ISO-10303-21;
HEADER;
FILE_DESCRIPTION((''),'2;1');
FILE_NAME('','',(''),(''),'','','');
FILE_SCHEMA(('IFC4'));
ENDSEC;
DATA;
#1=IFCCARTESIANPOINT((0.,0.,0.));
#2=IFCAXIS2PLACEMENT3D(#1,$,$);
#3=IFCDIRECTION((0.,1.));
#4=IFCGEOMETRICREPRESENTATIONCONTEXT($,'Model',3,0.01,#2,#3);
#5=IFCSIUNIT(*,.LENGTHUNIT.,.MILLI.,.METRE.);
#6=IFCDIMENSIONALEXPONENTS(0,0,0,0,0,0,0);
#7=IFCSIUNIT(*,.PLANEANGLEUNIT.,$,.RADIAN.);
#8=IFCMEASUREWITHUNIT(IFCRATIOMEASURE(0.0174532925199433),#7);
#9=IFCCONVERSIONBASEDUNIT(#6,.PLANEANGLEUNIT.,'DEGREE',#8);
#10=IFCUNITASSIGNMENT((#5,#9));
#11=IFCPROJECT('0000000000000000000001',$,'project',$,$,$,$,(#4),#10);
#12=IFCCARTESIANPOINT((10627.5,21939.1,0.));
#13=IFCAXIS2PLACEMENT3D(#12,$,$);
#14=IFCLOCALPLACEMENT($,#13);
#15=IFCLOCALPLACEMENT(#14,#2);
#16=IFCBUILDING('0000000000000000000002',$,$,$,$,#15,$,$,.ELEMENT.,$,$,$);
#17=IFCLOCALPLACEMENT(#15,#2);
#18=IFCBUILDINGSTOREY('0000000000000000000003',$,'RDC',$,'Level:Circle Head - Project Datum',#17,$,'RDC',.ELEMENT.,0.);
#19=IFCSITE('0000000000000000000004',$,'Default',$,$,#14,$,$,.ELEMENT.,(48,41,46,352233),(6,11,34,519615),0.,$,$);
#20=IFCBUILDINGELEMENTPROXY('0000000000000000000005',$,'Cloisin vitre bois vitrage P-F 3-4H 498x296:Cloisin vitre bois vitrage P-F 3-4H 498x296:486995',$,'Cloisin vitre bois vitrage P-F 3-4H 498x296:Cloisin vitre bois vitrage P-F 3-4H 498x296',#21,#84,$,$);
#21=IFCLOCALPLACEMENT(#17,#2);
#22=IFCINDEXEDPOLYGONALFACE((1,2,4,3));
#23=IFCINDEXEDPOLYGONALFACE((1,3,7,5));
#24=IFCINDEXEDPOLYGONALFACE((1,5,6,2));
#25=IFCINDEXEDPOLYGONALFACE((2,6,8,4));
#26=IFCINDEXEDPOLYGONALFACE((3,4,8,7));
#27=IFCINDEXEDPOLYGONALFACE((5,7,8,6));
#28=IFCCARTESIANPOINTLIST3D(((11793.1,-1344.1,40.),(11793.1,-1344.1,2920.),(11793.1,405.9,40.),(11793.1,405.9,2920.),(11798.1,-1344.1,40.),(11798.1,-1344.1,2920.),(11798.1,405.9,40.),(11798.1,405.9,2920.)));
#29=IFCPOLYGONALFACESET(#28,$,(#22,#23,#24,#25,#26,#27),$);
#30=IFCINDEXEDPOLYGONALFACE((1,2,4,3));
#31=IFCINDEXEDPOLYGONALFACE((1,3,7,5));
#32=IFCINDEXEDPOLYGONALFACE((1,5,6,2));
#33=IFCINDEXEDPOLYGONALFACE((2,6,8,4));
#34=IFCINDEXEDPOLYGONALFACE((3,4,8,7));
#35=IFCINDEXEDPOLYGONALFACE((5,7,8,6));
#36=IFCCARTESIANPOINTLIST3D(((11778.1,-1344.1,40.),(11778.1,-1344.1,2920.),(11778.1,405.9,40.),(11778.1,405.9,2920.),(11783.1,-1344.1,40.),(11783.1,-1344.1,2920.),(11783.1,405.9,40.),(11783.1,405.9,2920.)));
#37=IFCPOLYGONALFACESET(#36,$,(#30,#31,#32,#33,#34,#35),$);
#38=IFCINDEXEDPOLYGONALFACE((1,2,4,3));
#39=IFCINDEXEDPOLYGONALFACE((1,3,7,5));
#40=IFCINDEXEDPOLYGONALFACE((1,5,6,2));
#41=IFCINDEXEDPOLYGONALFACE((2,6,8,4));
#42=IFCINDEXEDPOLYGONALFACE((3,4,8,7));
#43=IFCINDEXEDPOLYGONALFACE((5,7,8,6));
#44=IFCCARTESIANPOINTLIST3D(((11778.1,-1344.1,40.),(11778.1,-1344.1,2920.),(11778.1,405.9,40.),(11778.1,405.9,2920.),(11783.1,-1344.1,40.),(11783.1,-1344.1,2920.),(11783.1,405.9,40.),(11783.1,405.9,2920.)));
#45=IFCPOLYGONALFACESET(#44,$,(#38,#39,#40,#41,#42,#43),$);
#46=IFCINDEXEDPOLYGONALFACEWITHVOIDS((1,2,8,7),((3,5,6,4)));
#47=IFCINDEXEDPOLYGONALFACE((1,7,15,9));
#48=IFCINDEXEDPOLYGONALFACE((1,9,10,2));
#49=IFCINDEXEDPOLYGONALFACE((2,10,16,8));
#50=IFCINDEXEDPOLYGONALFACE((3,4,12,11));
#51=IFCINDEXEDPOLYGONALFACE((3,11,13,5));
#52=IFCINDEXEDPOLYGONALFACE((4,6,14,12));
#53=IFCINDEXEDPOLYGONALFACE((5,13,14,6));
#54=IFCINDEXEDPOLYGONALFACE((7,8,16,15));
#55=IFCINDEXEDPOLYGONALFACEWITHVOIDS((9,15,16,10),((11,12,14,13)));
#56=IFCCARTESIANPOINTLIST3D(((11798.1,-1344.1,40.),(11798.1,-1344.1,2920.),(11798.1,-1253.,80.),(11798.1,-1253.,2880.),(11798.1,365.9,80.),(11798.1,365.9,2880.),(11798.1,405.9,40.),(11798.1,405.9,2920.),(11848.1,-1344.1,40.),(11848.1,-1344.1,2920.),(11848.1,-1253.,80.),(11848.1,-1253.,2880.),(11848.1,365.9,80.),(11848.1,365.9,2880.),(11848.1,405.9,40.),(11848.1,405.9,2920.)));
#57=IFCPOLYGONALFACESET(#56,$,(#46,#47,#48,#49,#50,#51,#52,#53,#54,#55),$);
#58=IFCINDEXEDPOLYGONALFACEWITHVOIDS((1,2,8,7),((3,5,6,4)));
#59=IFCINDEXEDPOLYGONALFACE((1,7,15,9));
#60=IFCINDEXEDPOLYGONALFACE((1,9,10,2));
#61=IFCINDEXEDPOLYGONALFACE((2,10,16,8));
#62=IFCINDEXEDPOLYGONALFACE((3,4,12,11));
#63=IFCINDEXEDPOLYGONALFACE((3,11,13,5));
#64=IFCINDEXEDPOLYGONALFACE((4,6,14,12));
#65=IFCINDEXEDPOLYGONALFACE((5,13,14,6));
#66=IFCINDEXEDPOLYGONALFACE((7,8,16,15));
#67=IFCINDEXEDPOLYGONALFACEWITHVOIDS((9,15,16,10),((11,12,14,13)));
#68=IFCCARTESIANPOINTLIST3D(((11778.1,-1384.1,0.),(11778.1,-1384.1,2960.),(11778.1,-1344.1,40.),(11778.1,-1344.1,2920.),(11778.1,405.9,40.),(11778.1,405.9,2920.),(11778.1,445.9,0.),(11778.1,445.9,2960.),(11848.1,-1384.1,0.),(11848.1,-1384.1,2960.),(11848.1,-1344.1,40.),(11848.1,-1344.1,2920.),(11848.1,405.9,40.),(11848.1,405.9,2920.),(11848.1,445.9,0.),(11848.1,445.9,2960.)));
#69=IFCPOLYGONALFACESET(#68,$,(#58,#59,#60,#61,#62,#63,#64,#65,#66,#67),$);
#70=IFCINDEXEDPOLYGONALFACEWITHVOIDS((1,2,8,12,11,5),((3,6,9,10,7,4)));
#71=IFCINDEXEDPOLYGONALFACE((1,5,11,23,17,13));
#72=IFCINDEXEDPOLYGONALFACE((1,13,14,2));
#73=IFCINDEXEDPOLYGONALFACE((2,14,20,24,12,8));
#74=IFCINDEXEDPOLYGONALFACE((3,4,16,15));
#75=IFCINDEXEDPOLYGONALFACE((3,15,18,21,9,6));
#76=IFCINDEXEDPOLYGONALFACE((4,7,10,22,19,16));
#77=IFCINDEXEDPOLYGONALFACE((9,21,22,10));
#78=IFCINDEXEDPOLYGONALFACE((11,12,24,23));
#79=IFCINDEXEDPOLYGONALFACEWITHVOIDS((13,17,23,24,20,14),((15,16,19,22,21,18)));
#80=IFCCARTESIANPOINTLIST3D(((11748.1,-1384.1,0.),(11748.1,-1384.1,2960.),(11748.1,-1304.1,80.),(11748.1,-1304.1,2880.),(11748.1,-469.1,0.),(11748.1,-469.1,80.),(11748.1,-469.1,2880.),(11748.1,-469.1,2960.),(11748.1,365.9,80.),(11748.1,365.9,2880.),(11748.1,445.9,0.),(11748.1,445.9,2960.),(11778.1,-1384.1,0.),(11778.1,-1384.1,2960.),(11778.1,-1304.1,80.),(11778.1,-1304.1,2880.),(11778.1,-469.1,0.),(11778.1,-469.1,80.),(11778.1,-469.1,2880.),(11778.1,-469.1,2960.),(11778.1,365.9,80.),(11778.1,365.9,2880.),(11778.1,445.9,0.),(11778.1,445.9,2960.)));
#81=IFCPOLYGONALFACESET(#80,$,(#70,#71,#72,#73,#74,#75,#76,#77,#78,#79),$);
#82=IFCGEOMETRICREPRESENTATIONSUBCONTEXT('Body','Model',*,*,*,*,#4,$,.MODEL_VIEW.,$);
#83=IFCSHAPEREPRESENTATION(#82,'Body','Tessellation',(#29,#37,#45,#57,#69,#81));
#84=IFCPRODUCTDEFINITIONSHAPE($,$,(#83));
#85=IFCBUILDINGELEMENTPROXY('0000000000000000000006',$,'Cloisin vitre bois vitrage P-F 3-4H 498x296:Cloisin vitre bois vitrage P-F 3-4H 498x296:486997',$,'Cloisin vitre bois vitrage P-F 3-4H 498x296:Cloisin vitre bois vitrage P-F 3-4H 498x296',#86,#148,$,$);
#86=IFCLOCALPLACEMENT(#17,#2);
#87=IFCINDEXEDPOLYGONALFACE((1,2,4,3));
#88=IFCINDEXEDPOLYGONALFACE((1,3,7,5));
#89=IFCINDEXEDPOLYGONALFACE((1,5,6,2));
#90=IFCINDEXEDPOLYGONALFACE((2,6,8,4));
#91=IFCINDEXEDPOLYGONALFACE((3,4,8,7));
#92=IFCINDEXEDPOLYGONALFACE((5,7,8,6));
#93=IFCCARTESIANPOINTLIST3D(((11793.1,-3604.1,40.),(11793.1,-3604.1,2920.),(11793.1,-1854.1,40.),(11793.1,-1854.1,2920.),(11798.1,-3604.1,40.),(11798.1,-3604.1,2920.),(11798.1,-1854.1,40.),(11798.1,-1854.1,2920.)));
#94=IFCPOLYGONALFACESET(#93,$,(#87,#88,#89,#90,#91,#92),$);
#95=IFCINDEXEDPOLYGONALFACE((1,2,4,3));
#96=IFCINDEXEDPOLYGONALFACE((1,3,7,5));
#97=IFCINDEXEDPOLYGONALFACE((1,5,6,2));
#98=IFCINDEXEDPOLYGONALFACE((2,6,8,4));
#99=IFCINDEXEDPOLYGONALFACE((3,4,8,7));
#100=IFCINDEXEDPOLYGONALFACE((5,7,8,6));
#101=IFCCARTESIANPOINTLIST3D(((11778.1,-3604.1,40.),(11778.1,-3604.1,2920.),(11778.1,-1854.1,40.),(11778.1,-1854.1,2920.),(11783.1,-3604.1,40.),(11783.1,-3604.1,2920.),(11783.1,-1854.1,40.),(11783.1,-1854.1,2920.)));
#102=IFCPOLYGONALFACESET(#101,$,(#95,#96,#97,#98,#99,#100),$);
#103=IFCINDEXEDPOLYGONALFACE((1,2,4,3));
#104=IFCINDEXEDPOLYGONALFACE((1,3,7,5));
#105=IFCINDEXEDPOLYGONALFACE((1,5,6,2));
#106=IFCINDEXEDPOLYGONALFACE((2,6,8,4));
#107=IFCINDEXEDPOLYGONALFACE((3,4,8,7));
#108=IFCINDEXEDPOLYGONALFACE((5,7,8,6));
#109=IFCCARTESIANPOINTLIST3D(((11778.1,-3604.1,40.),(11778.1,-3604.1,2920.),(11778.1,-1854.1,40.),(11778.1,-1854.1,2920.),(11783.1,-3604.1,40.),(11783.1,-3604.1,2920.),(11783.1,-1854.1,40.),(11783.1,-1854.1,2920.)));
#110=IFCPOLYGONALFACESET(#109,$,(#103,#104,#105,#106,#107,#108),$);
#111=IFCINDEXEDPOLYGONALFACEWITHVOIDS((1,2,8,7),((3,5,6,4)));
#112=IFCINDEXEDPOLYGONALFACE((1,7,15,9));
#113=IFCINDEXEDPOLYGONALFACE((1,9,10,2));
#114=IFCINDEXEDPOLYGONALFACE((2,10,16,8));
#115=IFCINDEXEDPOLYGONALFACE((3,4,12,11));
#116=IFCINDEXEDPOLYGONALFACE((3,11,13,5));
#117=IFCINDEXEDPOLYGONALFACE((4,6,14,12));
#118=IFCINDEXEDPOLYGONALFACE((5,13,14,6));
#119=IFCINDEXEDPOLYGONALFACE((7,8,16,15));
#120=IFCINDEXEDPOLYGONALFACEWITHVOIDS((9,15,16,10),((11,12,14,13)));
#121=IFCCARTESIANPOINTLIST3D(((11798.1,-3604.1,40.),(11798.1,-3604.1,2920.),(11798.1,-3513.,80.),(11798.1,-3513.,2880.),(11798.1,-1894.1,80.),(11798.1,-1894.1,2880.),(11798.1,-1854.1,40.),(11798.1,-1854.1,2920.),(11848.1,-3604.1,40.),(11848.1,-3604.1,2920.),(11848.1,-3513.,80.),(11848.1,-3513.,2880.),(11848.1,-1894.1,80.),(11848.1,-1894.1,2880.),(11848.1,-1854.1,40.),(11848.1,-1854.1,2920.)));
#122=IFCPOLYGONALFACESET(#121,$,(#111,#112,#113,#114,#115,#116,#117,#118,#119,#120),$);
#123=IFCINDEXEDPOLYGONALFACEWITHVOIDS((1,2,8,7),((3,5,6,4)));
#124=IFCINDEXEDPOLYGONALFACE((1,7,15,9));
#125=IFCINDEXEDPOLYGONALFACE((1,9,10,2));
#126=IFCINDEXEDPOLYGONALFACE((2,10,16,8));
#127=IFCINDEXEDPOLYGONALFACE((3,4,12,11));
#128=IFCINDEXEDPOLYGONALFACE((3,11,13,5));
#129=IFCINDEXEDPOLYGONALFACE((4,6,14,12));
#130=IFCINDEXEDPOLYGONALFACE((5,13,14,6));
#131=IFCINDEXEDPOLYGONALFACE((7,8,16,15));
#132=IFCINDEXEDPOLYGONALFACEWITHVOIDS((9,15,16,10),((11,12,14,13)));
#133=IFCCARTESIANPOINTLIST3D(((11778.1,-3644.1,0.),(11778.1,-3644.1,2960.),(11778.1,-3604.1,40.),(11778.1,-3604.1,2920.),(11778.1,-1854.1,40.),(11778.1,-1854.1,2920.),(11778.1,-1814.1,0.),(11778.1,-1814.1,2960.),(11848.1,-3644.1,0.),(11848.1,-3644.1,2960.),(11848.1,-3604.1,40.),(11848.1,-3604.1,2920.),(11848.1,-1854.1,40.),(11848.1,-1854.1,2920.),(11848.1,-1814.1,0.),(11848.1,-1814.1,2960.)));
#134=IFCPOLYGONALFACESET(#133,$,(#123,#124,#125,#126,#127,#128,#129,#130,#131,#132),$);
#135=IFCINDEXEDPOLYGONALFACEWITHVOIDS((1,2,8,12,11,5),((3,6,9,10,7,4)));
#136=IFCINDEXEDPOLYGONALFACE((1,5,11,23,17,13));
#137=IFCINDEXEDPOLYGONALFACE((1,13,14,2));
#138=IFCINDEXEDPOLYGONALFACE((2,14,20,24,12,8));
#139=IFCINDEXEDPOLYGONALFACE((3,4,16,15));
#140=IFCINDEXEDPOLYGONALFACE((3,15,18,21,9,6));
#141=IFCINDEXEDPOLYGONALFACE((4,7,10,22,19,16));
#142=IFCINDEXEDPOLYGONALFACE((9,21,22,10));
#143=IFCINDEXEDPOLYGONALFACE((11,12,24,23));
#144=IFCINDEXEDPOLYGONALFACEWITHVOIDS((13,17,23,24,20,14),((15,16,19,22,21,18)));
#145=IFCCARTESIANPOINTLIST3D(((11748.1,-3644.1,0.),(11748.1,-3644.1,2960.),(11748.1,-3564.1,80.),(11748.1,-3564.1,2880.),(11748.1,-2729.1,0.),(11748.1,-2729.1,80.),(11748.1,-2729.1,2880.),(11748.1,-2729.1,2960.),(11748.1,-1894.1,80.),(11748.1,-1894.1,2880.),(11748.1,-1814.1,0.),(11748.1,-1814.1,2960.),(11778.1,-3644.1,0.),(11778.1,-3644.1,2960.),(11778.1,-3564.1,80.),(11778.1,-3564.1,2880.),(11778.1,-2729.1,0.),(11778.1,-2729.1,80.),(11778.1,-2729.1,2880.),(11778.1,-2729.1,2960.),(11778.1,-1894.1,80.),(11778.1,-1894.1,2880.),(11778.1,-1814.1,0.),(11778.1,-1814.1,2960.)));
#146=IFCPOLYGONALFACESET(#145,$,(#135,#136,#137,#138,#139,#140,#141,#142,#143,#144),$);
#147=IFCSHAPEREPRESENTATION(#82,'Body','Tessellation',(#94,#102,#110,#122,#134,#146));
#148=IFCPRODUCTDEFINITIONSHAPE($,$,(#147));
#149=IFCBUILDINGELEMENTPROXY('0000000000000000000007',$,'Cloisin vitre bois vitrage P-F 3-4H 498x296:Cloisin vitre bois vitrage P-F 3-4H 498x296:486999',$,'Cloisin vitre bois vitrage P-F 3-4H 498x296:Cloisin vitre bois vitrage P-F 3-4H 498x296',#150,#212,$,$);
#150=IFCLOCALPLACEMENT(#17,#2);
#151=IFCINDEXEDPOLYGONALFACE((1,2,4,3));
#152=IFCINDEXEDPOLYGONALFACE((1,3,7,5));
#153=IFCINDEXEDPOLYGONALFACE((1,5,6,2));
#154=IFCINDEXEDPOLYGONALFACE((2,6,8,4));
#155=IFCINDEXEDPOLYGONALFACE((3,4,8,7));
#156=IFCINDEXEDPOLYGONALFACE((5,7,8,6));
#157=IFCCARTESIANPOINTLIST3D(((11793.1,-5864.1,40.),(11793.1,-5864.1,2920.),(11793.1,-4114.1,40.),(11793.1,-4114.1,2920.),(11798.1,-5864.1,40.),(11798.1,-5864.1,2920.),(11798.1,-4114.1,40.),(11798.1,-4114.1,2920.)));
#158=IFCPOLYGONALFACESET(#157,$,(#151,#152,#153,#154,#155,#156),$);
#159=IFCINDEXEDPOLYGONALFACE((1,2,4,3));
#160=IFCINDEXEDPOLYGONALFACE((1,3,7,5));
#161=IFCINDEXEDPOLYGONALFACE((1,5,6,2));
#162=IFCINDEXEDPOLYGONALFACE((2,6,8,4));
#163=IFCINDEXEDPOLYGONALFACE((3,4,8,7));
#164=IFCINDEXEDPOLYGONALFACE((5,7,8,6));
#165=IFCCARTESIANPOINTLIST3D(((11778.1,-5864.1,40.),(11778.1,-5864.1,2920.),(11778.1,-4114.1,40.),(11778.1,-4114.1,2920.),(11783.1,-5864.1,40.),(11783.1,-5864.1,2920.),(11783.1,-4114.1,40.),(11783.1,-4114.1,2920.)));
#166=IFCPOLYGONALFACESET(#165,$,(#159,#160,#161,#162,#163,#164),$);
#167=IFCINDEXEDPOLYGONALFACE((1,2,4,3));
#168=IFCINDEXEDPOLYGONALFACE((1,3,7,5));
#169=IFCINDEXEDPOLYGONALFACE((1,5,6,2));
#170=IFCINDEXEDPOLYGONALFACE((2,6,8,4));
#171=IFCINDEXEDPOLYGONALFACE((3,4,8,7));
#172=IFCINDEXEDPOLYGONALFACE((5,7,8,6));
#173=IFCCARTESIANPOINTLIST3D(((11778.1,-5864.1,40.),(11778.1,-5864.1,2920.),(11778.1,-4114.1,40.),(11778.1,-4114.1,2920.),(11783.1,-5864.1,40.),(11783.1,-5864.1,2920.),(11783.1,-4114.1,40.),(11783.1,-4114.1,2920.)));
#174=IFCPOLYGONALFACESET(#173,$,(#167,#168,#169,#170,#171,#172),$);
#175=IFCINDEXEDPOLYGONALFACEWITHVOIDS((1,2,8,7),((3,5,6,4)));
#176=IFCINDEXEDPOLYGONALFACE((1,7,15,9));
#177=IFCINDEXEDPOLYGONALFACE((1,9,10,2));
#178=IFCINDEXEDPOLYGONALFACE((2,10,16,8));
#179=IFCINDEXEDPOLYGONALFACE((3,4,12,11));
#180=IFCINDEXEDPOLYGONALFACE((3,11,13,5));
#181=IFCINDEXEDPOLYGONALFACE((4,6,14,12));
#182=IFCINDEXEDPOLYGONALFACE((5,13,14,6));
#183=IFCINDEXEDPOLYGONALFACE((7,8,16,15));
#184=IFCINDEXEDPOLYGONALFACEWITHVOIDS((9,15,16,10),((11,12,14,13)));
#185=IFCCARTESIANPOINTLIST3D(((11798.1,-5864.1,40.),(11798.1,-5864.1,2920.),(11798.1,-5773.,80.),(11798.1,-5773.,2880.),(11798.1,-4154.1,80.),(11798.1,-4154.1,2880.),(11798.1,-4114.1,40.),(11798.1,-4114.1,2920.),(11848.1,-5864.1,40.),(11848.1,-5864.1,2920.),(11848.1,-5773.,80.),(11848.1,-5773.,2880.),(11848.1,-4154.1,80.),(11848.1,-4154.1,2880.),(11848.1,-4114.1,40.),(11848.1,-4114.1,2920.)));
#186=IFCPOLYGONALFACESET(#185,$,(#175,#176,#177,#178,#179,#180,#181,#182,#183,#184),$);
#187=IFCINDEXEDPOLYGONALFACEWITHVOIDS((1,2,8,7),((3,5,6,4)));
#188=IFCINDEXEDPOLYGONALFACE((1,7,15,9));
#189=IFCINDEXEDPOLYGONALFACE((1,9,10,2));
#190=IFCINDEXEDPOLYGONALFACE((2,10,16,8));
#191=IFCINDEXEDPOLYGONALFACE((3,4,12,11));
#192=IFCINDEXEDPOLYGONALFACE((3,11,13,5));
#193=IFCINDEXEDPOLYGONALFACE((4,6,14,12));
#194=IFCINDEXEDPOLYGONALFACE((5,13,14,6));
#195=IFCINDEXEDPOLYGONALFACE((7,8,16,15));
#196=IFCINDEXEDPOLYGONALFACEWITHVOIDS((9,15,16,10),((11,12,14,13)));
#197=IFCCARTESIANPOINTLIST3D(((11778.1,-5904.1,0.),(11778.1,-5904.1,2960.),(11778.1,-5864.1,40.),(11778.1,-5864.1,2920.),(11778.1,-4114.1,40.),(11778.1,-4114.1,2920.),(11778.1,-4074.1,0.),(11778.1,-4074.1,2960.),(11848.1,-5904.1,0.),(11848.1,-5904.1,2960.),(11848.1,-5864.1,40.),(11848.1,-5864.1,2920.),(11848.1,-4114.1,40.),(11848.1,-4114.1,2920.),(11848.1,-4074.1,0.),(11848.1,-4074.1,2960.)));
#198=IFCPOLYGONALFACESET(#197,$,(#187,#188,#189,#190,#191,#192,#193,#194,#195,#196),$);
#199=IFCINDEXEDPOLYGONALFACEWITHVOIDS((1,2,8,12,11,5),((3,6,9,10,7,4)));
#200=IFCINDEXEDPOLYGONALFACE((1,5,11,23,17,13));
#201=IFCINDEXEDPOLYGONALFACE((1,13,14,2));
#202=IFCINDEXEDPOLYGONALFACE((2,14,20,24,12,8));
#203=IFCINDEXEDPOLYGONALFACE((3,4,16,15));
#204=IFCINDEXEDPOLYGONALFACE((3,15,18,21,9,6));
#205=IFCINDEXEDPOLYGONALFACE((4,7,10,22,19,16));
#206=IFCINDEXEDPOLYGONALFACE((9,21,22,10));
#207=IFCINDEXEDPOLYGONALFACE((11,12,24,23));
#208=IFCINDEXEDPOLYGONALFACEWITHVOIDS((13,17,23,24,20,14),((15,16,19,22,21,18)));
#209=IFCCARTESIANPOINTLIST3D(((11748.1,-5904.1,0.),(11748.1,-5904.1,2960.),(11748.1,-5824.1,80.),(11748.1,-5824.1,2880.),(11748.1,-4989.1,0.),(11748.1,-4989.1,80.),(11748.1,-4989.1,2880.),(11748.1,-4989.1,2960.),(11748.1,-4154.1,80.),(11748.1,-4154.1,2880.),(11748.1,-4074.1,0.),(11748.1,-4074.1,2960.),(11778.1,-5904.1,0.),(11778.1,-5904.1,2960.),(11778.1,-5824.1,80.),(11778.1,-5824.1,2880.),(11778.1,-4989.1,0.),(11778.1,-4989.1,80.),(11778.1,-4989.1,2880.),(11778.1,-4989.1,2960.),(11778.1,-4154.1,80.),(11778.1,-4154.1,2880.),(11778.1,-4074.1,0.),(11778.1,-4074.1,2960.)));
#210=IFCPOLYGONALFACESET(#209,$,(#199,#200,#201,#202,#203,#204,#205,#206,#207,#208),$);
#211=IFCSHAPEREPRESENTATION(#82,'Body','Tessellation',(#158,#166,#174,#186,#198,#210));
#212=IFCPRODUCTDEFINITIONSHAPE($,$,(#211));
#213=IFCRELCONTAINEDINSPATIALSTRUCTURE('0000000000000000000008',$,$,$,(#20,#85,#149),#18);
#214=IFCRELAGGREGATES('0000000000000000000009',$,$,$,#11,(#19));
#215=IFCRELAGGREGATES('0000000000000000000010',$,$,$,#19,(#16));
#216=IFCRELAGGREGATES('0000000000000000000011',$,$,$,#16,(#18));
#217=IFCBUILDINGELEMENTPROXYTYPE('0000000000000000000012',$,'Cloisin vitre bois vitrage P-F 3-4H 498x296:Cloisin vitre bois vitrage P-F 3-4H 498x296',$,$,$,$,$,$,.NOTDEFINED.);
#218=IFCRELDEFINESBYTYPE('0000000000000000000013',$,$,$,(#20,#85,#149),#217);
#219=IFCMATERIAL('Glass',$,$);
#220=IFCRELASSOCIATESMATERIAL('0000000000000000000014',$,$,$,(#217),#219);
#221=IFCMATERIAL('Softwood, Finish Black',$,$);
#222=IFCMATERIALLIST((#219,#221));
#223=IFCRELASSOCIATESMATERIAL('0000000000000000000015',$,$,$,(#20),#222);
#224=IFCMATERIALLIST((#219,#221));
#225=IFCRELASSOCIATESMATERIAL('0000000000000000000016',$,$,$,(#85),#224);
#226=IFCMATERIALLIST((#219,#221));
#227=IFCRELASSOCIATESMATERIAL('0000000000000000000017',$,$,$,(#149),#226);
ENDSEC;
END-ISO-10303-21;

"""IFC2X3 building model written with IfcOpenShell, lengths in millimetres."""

from ifc_helpers import new_model, entity, si_unit, converted_unit, direction, frame, frame_2d, origin, place, context, subcontext, project, spatial, polyline, rectangle, outline, extrude, source, transform, mapped, material, material_list, type_object, type_shapes, element, save


model = new_model("IFC2X3")

# Units and contexts
model_context = context("Model", 3, precision=0.01, world=origin(), true_north=direction((0.0, 1.0)))
body_context = subcontext(model_context, "Body", "Model", "MODEL_VIEW")
ifc_project = project(units=[si_unit("LENGTHUNIT", "METRE", prefix="MILLI"), converted_unit("PLANEANGLEUNIT", "DEGREE", entity("IfcRatioMeasure", 0.0174532925199433), si_unit("PLANEANGLEUNIT", "RADIAN"), dimensions=[0, 0, 0, 0, 0, 0, 0])], contexts=[model_context])

# Site, building, storey
site_placement = place(None, frame((10627.5, 21939.1, 0.0)))
site = spatial("IfcSite", under=ifc_project, at=site_placement, Name="Default", CompositionType="ELEMENT", RefLatitude=(48, 41, 46, 352233), RefLongitude=(6, 11, 34, 519615), RefElevation=0.0)
building_placement = place(site_placement, origin())
building = spatial("IfcBuilding", under=site, at=building_placement, CompositionType="ELEMENT")
storey_placement = place(building_placement, origin())
storey = spatial("IfcBuildingStorey", under=building, at=storey_placement, Name="RDC", ObjectType="Level:Circle Head - Project Datum", LongName="RDC", CompositionType="ELEMENT", Elevation=0.0)

# Building element proxies
ifc_material_1 = material(Name="Glass")
ifc_material_2 = material(Name="Softwood, Finish Black")
building_element_proxy_type_1 = type_object("IfcBuildingElementProxyType", Name="Cloisin vitre bois vitrage P-F 3-4H 498x296:Cloisin vitre bois vitrage P-F 3-4H 498x296", PredefinedType="NOTDEFINED", material=ifc_material_1)
shared_shape_1 = source(origin(), body_context, "Body", "SweptSolid", [
    extrude(rectangle(XDim=1750.0, YDim=5.0, at=frame_2d((0.0, 0.0), x_axis=(1.0, 0.0))), frame((0.0, 47.5, 40.0), z_axis=(0.0, 0.0, 1.0), x_axis=(-1.0, 0.0, 0.0)), (0.0, 0.0, 1.0), 2880.0),
    extrude(rectangle(XDim=1750.0, YDim=5.0, at=frame_2d((0.0, 0.0), x_axis=(1.0, 0.0))), frame((0.0, 32.5, 40.0), z_axis=(0.0, 0.0, 1.0), x_axis=(-1.0, 0.0, 0.0)), (0.0, 0.0, 1.0), 2880.0),
    extrude(rectangle(XDim=1750.0, YDim=5.0, at=frame_2d((0.0, 0.0), x_axis=(1.0, 0.0))), frame((0.0, 32.5, 40.0), z_axis=(0.0, 0.0, 1.0), x_axis=(-1.0, 0.0, 0.0)), (0.0, 0.0, 1.0), 2880.0),
    extrude(outline(polyline([(-1440.0, -875.0), (1440.0, -875.0), (1440.0, 875.0), (-1440.0, 875.0), (-1440.0, -875.0)]), holes=[polyline([(1400.0, 835.0), (1400.0, -783.9), (-1400.0, -783.9), (-1400.0, 835.0), (1400.0, 835.0)])]), frame((0.0, 50.0, 1480.0), z_axis=(0.0, 1.0, 0.0), x_axis=(0.0, 0.0, -1.0)), (0.0, 0.0, 1.0), 50.0),
    extrude(outline(polyline([(-1480.0, -915.0), (1480.0, -915.0), (1480.0, 915.0), (-1480.0, 915.0), (-1480.0, -915.0)]), holes=[polyline([(-1440.0, -875.0), (-1440.0, 875.0), (1440.0, 875.0), (1440.0, -875.0), (-1440.0, -875.0)])]), frame((0.0, 30.0, 1480.0), z_axis=(0.0, 1.0, 0.0), x_axis=(0.0, 0.0, -1.0)), (0.0, 0.0, 1.0), 70.0),
    extrude(outline(polyline([(-1480.0, -915.0), (1480.0, -915.0), (1480.0, 0.0), (1480.0, 915.0), (-1480.0, 915.0), (-1480.0, 0.0), (-1480.0, -915.0)]), holes=[polyline([(1400.0, 0.0), (1400.0, -835.0), (-1400.0, -835.0), (-1400.0, 0.0), (-1400.0, 835.0), (1400.0, 835.0), (1400.0, 0.0)])]), frame((0.0, 0.0, 1480.0), z_axis=(0.0, 1.0, 0.0), x_axis=(0.0, 0.0, 1.0)), (0.0, 0.0, 1.0), 30.0),
])
type_shapes(building_element_proxy_type_1, [shared_shape_1])
ifc_material_list_1 = material_list([ifc_material_1, ifc_material_2])
proxy_1_placement = place(storey_placement, frame((11748.1, -469.1, 0.0), z_axis=(0.0, 0.0, 1.0), x_axis=(0.0, -1.0, 0.0)))
element("IfcBuildingElementProxy", 1, at=proxy_1_placement, inside=storey, type_object=building_element_proxy_type_1, material=ifc_material_list_1, Name="Cloisin vitre bois vitrage P-F 3-4H 498x296:Cloisin vitre bois vitrage P-F 3-4H 498x296:486995", ObjectType="Cloisin vitre bois vitrage P-F 3-4H 498x296:Cloisin vitre bois vitrage P-F 3-4H 498x296", context=body_context, shape_type="MappedRepresentation", body=[
    mapped(shared_shape_1, transform((0.0, 0.0, 0.0), scale=1.0)),
])
ifc_material_list_2 = material_list([ifc_material_1, ifc_material_2])
proxy_2_placement = place(storey_placement, frame((11748.1, -2729.1, 0.0), z_axis=(0.0, 0.0, 1.0), x_axis=(0.0, -1.0, 0.0)))
element("IfcBuildingElementProxy", 2, at=proxy_2_placement, inside=storey, type_object=building_element_proxy_type_1, material=ifc_material_list_2, Name="Cloisin vitre bois vitrage P-F 3-4H 498x296:Cloisin vitre bois vitrage P-F 3-4H 498x296:486997", ObjectType="Cloisin vitre bois vitrage P-F 3-4H 498x296:Cloisin vitre bois vitrage P-F 3-4H 498x296", context=body_context, shape_type="MappedRepresentation", body=[
    mapped(shared_shape_1, transform((0.0, 0.0, 0.0), scale=1.0)),
])
ifc_material_list_3 = material_list([ifc_material_1, ifc_material_2])
proxy_3_placement = place(storey_placement, frame((11748.1, -4989.1, 0.0), z_axis=(0.0, 0.0, 1.0), x_axis=(0.0, -1.0, 0.0)))
element("IfcBuildingElementProxy", 3, at=proxy_3_placement, inside=storey, type_object=building_element_proxy_type_1, material=ifc_material_list_3, Name="Cloisin vitre bois vitrage P-F 3-4H 498x296:Cloisin vitre bois vitrage P-F 3-4H 498x296:486999", ObjectType="Cloisin vitre bois vitrage P-F 3-4H 498x296:Cloisin vitre bois vitrage P-F 3-4H 498x296", context=body_context, shape_type="MappedRepresentation", body=[
    mapped(shared_shape_1, transform((0.0, 0.0, 0.0), scale=1.0)),
])

save(model, "model.ifc")
